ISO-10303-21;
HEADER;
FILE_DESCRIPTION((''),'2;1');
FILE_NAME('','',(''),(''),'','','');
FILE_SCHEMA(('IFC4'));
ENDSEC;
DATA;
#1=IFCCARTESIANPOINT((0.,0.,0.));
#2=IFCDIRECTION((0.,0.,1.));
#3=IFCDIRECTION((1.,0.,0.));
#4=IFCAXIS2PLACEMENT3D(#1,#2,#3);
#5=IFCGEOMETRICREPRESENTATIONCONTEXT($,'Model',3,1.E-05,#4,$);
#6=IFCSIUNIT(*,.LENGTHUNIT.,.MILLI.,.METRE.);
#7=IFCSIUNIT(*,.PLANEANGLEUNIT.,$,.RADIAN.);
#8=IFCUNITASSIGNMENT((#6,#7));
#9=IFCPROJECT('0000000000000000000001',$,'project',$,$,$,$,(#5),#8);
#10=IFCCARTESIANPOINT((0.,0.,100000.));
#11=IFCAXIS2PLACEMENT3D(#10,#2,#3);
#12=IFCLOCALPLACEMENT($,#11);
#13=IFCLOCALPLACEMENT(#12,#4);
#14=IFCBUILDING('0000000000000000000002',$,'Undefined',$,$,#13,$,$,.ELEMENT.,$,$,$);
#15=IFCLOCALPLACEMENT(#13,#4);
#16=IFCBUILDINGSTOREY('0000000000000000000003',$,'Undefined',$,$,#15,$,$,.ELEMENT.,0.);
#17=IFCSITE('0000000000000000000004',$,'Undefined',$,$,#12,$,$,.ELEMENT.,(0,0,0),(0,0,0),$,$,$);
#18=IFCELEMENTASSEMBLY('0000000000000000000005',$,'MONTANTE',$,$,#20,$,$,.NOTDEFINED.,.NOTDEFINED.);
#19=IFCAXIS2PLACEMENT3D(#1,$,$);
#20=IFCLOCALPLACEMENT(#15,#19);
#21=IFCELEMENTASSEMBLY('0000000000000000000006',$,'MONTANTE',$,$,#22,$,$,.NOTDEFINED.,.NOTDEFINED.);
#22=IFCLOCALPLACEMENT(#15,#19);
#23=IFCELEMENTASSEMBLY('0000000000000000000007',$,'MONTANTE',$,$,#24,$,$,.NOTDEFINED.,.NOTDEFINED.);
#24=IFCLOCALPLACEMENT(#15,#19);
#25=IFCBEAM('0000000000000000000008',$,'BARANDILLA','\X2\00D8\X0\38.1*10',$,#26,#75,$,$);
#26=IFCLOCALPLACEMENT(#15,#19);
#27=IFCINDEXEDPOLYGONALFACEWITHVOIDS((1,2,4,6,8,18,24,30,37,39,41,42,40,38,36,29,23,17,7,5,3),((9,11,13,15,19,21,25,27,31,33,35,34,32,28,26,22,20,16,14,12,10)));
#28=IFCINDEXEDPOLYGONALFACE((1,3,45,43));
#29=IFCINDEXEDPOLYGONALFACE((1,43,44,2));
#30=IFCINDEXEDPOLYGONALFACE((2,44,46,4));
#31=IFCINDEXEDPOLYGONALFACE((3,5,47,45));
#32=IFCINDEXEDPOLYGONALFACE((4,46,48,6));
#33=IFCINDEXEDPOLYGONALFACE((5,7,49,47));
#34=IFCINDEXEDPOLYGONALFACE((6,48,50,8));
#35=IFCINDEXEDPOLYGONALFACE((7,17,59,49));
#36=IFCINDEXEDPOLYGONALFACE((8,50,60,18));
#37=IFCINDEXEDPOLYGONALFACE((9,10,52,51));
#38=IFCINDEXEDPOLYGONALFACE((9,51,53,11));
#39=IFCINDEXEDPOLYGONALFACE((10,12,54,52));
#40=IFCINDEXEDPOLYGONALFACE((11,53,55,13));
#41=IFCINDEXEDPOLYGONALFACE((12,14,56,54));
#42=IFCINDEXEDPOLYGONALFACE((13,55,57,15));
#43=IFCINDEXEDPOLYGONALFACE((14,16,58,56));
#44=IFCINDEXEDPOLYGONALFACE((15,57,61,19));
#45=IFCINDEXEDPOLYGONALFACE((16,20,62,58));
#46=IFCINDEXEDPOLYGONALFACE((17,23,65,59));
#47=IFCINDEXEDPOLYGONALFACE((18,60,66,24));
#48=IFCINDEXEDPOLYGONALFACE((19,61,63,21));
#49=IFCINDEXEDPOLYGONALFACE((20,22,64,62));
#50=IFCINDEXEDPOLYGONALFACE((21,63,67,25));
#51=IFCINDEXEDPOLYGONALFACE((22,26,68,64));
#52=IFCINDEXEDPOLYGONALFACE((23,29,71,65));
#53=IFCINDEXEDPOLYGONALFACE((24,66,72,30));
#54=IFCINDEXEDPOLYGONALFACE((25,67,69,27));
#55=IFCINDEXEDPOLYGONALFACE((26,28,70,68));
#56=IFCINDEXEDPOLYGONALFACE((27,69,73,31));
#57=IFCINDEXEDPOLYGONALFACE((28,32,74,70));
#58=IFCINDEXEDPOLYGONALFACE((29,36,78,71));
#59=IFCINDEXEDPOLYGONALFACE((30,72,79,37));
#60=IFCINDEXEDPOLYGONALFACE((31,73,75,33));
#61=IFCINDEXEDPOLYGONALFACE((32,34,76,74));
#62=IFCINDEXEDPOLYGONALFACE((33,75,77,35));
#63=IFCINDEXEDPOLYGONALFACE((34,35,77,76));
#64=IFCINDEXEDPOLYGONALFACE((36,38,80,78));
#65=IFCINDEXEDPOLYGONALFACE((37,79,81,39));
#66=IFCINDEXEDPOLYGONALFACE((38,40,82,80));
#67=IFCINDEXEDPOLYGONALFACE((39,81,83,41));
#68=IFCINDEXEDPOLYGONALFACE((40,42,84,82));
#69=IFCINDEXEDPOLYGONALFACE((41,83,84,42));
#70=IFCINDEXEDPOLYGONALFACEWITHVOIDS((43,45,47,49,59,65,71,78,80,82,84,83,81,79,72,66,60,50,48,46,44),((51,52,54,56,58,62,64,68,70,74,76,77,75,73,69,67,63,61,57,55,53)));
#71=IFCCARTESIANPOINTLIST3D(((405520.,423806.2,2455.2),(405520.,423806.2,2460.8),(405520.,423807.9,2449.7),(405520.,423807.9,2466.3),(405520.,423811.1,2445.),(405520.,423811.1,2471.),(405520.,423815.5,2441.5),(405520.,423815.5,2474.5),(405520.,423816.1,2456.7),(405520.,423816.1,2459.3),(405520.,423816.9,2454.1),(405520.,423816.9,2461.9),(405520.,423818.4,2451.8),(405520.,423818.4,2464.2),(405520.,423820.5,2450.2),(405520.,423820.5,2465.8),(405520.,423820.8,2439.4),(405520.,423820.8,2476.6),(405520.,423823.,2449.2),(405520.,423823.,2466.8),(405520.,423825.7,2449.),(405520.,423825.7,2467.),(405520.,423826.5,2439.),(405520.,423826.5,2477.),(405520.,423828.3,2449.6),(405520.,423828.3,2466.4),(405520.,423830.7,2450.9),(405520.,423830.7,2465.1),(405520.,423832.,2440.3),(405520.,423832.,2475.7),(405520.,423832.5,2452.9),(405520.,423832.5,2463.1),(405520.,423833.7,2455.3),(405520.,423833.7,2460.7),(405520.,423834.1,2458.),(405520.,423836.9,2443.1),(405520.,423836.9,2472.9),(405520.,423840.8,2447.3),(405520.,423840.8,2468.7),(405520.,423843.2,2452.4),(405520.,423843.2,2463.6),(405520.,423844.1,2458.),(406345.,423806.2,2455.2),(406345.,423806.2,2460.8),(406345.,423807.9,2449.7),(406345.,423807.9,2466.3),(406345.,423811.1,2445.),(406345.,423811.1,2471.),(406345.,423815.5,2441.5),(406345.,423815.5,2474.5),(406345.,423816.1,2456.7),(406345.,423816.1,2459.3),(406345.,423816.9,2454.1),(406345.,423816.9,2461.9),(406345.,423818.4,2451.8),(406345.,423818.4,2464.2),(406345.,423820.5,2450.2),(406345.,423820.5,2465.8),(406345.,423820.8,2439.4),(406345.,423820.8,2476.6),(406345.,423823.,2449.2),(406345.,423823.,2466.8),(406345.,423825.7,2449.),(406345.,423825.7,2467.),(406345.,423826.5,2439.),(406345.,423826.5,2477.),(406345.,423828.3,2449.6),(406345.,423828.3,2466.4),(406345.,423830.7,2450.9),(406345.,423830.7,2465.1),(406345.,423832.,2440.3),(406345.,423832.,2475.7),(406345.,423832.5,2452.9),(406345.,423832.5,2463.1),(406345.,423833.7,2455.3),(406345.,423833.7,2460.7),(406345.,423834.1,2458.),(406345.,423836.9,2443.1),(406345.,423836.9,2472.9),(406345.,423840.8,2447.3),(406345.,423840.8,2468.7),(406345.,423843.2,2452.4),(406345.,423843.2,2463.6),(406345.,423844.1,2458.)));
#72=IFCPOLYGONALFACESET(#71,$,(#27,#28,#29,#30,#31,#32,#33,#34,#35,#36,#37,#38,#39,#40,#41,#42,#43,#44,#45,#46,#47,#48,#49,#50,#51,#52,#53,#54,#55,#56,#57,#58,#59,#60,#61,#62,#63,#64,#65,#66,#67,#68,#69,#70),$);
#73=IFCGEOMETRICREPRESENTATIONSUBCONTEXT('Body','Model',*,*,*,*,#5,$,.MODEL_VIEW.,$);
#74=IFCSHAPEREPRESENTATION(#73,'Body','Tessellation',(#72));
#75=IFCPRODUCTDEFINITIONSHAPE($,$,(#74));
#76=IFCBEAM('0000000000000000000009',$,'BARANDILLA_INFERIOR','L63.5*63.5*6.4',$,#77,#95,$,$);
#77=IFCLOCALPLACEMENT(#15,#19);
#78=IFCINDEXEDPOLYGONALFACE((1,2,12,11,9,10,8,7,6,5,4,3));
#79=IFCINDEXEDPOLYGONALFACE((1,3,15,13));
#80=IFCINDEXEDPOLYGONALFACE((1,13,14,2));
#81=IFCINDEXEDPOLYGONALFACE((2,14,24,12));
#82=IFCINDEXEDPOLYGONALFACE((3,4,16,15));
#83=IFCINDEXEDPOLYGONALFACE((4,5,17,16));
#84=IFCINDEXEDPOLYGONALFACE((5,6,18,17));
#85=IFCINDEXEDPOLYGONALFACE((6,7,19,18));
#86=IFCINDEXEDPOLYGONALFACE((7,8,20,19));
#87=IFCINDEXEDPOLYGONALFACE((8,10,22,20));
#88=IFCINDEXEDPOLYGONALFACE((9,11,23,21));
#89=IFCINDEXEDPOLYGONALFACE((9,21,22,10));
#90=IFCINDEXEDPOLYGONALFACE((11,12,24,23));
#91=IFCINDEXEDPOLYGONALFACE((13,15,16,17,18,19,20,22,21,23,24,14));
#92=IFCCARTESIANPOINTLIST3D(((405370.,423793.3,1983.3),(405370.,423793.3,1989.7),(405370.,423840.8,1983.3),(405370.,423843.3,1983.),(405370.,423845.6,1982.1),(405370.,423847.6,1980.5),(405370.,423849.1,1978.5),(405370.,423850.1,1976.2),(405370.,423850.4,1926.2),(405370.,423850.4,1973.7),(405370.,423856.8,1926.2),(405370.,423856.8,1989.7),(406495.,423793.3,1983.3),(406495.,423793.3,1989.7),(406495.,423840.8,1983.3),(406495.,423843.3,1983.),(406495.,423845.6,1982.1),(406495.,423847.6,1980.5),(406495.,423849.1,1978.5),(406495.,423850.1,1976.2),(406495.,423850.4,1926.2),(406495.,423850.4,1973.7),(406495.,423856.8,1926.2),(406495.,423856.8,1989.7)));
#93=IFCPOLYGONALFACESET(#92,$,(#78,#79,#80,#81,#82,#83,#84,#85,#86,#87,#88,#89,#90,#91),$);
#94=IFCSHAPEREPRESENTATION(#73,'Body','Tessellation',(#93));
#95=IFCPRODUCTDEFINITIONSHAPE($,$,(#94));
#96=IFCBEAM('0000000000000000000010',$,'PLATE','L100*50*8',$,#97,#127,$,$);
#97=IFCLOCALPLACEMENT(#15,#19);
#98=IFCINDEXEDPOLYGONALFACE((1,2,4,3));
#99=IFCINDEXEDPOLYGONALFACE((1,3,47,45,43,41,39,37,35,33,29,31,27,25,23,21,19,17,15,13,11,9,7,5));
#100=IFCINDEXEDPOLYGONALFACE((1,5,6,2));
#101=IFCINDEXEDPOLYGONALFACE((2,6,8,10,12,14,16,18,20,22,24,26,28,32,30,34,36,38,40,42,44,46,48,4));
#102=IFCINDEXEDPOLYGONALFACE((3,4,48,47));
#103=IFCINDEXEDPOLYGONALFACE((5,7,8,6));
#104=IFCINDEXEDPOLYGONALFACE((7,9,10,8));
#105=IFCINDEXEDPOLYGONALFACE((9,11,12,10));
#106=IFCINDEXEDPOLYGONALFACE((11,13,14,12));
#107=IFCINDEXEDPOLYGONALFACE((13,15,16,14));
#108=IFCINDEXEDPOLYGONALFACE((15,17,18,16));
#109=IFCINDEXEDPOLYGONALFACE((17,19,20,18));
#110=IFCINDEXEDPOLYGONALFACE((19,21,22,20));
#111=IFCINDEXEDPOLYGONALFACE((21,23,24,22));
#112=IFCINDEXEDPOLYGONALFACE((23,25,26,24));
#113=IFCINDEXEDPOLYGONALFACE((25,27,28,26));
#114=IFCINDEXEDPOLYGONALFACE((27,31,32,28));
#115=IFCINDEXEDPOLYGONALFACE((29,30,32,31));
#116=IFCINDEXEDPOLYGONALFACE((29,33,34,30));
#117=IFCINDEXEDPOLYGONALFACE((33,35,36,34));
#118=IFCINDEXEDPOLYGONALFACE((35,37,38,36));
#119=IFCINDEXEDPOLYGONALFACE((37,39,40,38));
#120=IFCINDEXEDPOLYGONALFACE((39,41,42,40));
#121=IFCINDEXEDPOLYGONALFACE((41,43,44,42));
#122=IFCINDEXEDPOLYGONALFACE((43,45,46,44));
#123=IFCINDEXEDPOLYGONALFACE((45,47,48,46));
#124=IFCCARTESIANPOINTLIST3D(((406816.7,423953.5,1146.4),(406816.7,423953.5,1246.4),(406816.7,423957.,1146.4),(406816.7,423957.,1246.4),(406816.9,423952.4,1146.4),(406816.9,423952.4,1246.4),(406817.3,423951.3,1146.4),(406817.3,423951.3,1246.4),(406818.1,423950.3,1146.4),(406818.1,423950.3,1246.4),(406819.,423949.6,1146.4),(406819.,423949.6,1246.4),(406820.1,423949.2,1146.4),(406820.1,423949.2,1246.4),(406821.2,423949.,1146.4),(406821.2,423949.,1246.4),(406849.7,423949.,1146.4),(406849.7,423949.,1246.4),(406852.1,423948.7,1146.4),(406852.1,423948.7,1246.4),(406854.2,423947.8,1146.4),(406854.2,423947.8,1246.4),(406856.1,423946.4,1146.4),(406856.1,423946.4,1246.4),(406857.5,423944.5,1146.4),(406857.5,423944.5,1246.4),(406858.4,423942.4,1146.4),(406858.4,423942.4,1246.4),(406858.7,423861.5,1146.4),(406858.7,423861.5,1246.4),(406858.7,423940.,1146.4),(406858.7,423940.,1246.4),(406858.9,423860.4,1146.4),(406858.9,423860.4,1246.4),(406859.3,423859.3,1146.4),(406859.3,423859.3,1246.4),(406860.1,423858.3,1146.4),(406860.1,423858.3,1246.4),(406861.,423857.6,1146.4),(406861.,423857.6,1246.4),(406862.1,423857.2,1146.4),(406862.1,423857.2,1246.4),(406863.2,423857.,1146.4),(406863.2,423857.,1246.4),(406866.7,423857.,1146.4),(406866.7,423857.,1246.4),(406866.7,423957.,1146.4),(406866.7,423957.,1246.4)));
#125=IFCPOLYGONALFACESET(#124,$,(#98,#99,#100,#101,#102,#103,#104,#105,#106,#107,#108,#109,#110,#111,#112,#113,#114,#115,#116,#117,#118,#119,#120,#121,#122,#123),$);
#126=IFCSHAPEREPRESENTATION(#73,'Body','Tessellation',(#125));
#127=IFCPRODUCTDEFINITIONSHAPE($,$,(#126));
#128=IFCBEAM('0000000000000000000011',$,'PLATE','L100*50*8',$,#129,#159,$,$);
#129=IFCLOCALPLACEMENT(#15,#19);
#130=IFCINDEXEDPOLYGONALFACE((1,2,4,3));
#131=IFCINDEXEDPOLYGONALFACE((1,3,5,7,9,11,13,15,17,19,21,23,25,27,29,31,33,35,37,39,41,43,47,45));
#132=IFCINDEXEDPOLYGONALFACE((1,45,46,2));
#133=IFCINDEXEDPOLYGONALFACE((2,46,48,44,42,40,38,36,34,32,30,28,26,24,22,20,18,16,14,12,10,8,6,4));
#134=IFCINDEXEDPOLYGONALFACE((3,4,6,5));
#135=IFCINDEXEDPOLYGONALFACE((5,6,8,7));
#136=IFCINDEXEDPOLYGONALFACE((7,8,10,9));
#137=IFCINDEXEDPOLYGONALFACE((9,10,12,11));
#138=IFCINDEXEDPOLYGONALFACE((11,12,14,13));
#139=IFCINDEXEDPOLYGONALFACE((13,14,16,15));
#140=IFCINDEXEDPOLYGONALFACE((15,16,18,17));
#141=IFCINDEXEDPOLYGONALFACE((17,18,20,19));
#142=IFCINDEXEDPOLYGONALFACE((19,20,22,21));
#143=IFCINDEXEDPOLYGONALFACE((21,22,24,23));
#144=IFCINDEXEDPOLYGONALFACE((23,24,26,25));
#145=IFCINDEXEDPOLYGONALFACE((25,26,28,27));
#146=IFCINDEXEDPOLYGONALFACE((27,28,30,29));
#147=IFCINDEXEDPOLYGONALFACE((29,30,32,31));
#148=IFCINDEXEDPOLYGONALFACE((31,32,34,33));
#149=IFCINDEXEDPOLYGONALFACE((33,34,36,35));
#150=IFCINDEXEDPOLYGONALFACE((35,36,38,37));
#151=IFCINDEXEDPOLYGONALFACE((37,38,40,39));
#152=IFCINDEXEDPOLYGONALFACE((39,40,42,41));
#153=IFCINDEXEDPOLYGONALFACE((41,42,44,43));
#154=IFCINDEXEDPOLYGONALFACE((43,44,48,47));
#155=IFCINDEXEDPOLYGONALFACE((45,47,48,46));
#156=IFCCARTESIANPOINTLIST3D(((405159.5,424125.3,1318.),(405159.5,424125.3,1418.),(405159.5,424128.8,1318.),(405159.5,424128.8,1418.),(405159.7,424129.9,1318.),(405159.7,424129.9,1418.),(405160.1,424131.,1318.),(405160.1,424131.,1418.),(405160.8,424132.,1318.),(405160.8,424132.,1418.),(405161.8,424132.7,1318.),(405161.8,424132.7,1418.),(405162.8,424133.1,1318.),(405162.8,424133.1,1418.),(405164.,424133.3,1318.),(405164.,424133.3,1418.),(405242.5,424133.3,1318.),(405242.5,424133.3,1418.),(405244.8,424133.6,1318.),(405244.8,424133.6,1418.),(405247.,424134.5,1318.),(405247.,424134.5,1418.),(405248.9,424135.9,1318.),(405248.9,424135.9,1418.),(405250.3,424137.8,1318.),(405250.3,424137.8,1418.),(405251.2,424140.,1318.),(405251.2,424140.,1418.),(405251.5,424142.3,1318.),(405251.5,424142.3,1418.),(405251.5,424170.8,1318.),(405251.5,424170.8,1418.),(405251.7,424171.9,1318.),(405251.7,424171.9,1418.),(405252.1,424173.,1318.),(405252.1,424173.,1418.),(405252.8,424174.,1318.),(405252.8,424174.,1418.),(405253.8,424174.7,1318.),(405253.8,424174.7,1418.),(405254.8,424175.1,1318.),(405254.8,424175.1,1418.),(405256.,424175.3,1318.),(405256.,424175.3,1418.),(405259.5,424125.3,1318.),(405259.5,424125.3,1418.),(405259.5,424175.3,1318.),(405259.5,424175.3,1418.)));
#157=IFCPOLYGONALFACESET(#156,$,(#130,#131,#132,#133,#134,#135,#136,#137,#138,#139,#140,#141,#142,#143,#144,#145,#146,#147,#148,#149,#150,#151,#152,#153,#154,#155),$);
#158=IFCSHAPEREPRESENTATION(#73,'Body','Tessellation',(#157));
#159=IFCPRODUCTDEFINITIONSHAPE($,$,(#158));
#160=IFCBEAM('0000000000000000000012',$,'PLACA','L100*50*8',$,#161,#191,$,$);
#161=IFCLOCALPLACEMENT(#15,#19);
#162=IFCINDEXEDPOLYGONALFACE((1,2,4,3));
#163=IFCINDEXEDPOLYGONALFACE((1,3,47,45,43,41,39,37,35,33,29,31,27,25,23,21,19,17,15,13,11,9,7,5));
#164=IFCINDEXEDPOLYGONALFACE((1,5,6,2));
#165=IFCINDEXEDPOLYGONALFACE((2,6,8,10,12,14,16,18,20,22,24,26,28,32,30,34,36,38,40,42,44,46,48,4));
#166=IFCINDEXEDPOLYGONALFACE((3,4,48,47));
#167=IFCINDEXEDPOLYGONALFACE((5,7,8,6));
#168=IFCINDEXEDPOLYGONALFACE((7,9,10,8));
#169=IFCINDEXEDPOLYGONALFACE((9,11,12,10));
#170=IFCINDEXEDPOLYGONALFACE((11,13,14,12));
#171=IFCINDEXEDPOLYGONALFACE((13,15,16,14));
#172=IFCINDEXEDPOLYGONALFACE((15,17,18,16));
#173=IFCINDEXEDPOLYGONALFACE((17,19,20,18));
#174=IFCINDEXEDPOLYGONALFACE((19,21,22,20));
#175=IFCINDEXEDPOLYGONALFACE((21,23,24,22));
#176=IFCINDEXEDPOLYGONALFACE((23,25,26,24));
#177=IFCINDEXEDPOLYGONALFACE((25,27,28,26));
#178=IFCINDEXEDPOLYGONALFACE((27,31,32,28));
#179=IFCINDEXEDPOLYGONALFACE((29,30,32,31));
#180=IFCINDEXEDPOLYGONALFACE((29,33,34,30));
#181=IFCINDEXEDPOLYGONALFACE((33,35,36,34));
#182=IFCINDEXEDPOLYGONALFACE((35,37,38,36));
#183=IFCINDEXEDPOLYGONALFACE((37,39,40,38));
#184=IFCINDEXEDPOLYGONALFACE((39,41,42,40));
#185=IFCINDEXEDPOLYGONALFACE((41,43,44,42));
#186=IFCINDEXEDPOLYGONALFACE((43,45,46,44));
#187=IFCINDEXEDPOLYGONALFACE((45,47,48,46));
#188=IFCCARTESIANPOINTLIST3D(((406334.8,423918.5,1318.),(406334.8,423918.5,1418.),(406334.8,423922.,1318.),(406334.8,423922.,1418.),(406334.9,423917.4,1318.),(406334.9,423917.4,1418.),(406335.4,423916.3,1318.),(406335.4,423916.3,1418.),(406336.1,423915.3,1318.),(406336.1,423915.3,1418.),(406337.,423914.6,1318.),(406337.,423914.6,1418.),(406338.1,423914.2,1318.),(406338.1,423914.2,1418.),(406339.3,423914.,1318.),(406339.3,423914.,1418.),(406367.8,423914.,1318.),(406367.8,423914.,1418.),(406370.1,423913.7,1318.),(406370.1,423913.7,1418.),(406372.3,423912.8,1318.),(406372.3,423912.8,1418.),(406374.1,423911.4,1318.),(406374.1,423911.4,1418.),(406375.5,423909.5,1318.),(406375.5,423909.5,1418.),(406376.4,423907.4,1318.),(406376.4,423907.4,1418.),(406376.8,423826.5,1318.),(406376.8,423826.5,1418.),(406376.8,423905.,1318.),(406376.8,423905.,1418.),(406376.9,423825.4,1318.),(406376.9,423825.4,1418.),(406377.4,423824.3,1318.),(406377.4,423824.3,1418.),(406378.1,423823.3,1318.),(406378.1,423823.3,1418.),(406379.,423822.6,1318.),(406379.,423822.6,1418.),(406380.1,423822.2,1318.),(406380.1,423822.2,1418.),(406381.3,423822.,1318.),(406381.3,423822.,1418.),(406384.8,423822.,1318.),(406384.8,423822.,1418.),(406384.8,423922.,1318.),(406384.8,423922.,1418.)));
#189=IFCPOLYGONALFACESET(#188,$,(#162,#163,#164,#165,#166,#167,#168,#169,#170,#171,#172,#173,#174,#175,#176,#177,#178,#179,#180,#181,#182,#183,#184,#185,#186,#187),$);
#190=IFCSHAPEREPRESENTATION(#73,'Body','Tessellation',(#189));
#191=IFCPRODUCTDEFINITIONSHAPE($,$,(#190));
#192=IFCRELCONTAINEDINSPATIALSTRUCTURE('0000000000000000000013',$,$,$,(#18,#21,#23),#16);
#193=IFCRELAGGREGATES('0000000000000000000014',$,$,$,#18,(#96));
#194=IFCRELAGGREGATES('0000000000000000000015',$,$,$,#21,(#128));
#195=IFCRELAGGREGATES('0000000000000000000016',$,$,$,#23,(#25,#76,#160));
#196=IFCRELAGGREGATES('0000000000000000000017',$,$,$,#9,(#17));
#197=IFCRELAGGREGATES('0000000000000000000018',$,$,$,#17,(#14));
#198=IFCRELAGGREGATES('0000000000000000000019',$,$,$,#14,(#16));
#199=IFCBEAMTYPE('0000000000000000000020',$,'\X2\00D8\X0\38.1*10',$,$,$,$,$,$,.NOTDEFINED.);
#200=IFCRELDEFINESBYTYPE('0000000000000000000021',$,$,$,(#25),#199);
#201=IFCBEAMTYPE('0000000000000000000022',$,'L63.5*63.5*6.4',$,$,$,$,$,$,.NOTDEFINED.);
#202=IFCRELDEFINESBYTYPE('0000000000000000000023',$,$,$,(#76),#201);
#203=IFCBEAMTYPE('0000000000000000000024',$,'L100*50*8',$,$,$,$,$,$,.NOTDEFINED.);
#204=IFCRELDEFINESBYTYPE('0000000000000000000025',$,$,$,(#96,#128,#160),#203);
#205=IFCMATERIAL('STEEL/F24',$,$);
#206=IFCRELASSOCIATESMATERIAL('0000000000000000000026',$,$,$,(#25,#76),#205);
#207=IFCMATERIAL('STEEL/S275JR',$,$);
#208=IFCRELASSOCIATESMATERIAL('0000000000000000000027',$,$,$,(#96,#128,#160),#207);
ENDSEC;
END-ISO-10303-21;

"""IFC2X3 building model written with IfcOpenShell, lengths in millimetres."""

from ifc_helpers import new_model, si_unit, frame, origin_with_axes, origin_2d_with_axis, place, context, subcontext, project, spatial, hollow_circle, l_section, extrude, clip, halfspace, material, type_object, element, aggregate, save


model = new_model("IFC2X3")

# Units and contexts
model_context = context("Model", 3, precision=1e-05, world=origin_with_axes())
body_context = subcontext(model_context, "Body", "Model", "MODEL_VIEW")
ifc_project = project(units=[si_unit("LENGTHUNIT", "METRE", prefix="MILLI"), si_unit("PLANEANGLEUNIT", "RADIAN")], contexts=[model_context])

# Site, building, storey
site_placement = place(None, frame((0.0, 0.0, 100000.0), z_axis=(0.0, 0.0, 1.0), x_axis=(1.0, 0.0, 0.0)))
site = spatial("IfcSite", under=ifc_project, at=site_placement, Name="Undefined", CompositionType="ELEMENT", RefLatitude=(0, 0, 0), RefLongitude=(0, 0, 0))
building_placement = place(site_placement, origin_with_axes())
building = spatial("IfcBuilding", under=site, at=building_placement, Name="Undefined", CompositionType="ELEMENT")
storey_placement = place(building_placement, origin_with_axes())
storey = spatial("IfcBuildingStorey", under=building, at=storey_placement, Name="Undefined", CompositionType="ELEMENT", Elevation=0.0)

# Element assemblies
assembly_1_placement = place(storey_placement, origin_with_axes())
assembly_1 = element("IfcElementAssembly", 1, at=assembly_1_placement, inside=storey, Name="MONTANTE", AssemblyPlace="NOTDEFINED", PredefinedType="NOTDEFINED")
ifc_material_1 = material(Name="STEEL/F24")
assembly_2_placement = place(storey_placement, origin_with_axes())
assembly_2 = element("IfcElementAssembly", 2, at=assembly_2_placement, inside=storey, Name="MONTANTE", AssemblyPlace="NOTDEFINED", PredefinedType="NOTDEFINED")

# Element assembly, beams
assembly_3_placement = place(storey_placement, origin_with_axes())
assembly_3 = element("IfcElementAssembly", 3, at=assembly_3_placement, inside=storey, Name="MONTANTE", AssemblyPlace="NOTDEFINED", PredefinedType="NOTDEFINED")
beam_type_1 = type_object("IfcBeamType", Name="Ø38.1*10", PredefinedType="NOTDEFINED")
beam_1_placement = place(assembly_3_placement, frame((405520.0, 423825.0, 2458.0), z_axis=(0.0, 0.0, -1.0), x_axis=(1.0, 0.0, 0.0)))
beam_1 = element("IfcBeam", 4, at=beam_1_placement, type_object=beam_type_1, material=ifc_material_1, Name="BARANDILLA", Description="Ø38.1*10", context=body_context, shape_type="Clipping", body=[
    clip(extrude(hollow_circle(Radius=19.1, WallThickness=10.0, at=origin_2d_with_axis()), frame((825.0, 0.0, 0.0), z_axis=(-1.0, 0.0, 0.0), x_axis=(0.0, -1.0, 0.0)), (0.0, 0.0, 1.0), 825.0), halfspace(frame((0.0, 0.0, 0.0), z_axis=(1.0, 0.0, 0.0), x_axis=(0.0, -1.0, 0.0)), True)),
])
beam_type_2 = type_object("IfcBeamType", Name="L63.5*63.5*6.4", PredefinedType="NOTDEFINED")
beam_2_placement = place(assembly_3_placement, frame((405370.0, 423825.0, 1958.0), z_axis=(0.0, -1.0, 0.0), x_axis=(1.0, 0.0, 0.0)))
beam_2 = element("IfcBeam", 5, at=beam_2_placement, type_object=beam_type_2, material=ifc_material_1, Name="BARANDILLA_INFERIOR", Description="L63.5*63.5*6.4", context=body_context, shape_type="SweptSolid", body=[
    extrude(l_section(Depth=63.5, Width=63.5, Thickness=6.4, FilletRadius=9.6, at=origin_2d_with_axis()), frame((1125.0, 0.0, 0.0), z_axis=(-1.0, 0.0, 0.0), x_axis=(0.0, -1.0, 0.0)), (0.0, 0.0, 1.0), 1125.0),
])

# Beams
ifc_material_2 = material(Name="STEEL/S275JR")
beam_type_3 = type_object("IfcBeamType", Name="L100*50*8", PredefinedType="NOTDEFINED")
beam_3_placement = place(assembly_1_placement, frame((406841.7, 423907.0, 1246.4), z_axis=(0.0, -1.0, 0.0), x_axis=(0.0, 0.0, -1.0)))
beam_3 = element("IfcBeam", 6, at=beam_3_placement, type_object=beam_type_3, material=ifc_material_2, Name="PLATE", Description="L100*50*8", context=body_context, shape_type="SweptSolid", body=[
    extrude(l_section(Depth=100.0, Width=50.0, Thickness=8.0, FilletRadius=9.0, EdgeRadius=4.5, at=origin_2d_with_axis()), frame((100.0, 0.0, 0.0), z_axis=(-1.0, 0.0, 0.0), x_axis=(0.0, -1.0, 0.0)), (0.0, 0.0, 1.0), 100.0),
])
beam_4_placement = place(assembly_2_placement, frame((405209.5, 424150.3, 1418.0), z_axis=(-1.0, 0.0, 0.0), x_axis=(0.0, 0.0, -1.0)))
beam_4 = element("IfcBeam", 7, at=beam_4_placement, type_object=beam_type_3, material=ifc_material_2, Name="PLATE", Description="L100*50*8", context=body_context, shape_type="SweptSolid", body=[
    extrude(l_section(Depth=100.0, Width=50.0, Thickness=8.0, FilletRadius=9.0, EdgeRadius=4.5, at=origin_2d_with_axis()), frame((100.0, 0.0, 0.0), z_axis=(-1.0, 0.0, 0.0), x_axis=(0.0, -1.0, 0.0)), (0.0, 0.0, 1.0), 100.0),
])
beam_5_placement = place(assembly_3_placement, frame((406359.8, 423872.0, 1418.0), z_axis=(0.0, -1.0, 0.0), x_axis=(0.0, 0.0, -1.0)))
beam_5 = element("IfcBeam", 8, at=beam_5_placement, type_object=beam_type_3, material=ifc_material_2, Name="PLACA", Description="L100*50*8", context=body_context, shape_type="SweptSolid", body=[
    extrude(l_section(Depth=100.0, Width=50.0, Thickness=8.0, FilletRadius=9.0, EdgeRadius=4.5, at=origin_2d_with_axis()), frame((100.0, 0.0, 0.0), z_axis=(-1.0, 0.0, 0.0), x_axis=(0.0, -1.0, 0.0)), (0.0, 0.0, 1.0), 100.0),
])

aggregate(assembly_1, [beam_3])

aggregate(assembly_2, [beam_4])

aggregate(assembly_3, [beam_1, beam_2, beam_5])

save(model, "model.ifc")
